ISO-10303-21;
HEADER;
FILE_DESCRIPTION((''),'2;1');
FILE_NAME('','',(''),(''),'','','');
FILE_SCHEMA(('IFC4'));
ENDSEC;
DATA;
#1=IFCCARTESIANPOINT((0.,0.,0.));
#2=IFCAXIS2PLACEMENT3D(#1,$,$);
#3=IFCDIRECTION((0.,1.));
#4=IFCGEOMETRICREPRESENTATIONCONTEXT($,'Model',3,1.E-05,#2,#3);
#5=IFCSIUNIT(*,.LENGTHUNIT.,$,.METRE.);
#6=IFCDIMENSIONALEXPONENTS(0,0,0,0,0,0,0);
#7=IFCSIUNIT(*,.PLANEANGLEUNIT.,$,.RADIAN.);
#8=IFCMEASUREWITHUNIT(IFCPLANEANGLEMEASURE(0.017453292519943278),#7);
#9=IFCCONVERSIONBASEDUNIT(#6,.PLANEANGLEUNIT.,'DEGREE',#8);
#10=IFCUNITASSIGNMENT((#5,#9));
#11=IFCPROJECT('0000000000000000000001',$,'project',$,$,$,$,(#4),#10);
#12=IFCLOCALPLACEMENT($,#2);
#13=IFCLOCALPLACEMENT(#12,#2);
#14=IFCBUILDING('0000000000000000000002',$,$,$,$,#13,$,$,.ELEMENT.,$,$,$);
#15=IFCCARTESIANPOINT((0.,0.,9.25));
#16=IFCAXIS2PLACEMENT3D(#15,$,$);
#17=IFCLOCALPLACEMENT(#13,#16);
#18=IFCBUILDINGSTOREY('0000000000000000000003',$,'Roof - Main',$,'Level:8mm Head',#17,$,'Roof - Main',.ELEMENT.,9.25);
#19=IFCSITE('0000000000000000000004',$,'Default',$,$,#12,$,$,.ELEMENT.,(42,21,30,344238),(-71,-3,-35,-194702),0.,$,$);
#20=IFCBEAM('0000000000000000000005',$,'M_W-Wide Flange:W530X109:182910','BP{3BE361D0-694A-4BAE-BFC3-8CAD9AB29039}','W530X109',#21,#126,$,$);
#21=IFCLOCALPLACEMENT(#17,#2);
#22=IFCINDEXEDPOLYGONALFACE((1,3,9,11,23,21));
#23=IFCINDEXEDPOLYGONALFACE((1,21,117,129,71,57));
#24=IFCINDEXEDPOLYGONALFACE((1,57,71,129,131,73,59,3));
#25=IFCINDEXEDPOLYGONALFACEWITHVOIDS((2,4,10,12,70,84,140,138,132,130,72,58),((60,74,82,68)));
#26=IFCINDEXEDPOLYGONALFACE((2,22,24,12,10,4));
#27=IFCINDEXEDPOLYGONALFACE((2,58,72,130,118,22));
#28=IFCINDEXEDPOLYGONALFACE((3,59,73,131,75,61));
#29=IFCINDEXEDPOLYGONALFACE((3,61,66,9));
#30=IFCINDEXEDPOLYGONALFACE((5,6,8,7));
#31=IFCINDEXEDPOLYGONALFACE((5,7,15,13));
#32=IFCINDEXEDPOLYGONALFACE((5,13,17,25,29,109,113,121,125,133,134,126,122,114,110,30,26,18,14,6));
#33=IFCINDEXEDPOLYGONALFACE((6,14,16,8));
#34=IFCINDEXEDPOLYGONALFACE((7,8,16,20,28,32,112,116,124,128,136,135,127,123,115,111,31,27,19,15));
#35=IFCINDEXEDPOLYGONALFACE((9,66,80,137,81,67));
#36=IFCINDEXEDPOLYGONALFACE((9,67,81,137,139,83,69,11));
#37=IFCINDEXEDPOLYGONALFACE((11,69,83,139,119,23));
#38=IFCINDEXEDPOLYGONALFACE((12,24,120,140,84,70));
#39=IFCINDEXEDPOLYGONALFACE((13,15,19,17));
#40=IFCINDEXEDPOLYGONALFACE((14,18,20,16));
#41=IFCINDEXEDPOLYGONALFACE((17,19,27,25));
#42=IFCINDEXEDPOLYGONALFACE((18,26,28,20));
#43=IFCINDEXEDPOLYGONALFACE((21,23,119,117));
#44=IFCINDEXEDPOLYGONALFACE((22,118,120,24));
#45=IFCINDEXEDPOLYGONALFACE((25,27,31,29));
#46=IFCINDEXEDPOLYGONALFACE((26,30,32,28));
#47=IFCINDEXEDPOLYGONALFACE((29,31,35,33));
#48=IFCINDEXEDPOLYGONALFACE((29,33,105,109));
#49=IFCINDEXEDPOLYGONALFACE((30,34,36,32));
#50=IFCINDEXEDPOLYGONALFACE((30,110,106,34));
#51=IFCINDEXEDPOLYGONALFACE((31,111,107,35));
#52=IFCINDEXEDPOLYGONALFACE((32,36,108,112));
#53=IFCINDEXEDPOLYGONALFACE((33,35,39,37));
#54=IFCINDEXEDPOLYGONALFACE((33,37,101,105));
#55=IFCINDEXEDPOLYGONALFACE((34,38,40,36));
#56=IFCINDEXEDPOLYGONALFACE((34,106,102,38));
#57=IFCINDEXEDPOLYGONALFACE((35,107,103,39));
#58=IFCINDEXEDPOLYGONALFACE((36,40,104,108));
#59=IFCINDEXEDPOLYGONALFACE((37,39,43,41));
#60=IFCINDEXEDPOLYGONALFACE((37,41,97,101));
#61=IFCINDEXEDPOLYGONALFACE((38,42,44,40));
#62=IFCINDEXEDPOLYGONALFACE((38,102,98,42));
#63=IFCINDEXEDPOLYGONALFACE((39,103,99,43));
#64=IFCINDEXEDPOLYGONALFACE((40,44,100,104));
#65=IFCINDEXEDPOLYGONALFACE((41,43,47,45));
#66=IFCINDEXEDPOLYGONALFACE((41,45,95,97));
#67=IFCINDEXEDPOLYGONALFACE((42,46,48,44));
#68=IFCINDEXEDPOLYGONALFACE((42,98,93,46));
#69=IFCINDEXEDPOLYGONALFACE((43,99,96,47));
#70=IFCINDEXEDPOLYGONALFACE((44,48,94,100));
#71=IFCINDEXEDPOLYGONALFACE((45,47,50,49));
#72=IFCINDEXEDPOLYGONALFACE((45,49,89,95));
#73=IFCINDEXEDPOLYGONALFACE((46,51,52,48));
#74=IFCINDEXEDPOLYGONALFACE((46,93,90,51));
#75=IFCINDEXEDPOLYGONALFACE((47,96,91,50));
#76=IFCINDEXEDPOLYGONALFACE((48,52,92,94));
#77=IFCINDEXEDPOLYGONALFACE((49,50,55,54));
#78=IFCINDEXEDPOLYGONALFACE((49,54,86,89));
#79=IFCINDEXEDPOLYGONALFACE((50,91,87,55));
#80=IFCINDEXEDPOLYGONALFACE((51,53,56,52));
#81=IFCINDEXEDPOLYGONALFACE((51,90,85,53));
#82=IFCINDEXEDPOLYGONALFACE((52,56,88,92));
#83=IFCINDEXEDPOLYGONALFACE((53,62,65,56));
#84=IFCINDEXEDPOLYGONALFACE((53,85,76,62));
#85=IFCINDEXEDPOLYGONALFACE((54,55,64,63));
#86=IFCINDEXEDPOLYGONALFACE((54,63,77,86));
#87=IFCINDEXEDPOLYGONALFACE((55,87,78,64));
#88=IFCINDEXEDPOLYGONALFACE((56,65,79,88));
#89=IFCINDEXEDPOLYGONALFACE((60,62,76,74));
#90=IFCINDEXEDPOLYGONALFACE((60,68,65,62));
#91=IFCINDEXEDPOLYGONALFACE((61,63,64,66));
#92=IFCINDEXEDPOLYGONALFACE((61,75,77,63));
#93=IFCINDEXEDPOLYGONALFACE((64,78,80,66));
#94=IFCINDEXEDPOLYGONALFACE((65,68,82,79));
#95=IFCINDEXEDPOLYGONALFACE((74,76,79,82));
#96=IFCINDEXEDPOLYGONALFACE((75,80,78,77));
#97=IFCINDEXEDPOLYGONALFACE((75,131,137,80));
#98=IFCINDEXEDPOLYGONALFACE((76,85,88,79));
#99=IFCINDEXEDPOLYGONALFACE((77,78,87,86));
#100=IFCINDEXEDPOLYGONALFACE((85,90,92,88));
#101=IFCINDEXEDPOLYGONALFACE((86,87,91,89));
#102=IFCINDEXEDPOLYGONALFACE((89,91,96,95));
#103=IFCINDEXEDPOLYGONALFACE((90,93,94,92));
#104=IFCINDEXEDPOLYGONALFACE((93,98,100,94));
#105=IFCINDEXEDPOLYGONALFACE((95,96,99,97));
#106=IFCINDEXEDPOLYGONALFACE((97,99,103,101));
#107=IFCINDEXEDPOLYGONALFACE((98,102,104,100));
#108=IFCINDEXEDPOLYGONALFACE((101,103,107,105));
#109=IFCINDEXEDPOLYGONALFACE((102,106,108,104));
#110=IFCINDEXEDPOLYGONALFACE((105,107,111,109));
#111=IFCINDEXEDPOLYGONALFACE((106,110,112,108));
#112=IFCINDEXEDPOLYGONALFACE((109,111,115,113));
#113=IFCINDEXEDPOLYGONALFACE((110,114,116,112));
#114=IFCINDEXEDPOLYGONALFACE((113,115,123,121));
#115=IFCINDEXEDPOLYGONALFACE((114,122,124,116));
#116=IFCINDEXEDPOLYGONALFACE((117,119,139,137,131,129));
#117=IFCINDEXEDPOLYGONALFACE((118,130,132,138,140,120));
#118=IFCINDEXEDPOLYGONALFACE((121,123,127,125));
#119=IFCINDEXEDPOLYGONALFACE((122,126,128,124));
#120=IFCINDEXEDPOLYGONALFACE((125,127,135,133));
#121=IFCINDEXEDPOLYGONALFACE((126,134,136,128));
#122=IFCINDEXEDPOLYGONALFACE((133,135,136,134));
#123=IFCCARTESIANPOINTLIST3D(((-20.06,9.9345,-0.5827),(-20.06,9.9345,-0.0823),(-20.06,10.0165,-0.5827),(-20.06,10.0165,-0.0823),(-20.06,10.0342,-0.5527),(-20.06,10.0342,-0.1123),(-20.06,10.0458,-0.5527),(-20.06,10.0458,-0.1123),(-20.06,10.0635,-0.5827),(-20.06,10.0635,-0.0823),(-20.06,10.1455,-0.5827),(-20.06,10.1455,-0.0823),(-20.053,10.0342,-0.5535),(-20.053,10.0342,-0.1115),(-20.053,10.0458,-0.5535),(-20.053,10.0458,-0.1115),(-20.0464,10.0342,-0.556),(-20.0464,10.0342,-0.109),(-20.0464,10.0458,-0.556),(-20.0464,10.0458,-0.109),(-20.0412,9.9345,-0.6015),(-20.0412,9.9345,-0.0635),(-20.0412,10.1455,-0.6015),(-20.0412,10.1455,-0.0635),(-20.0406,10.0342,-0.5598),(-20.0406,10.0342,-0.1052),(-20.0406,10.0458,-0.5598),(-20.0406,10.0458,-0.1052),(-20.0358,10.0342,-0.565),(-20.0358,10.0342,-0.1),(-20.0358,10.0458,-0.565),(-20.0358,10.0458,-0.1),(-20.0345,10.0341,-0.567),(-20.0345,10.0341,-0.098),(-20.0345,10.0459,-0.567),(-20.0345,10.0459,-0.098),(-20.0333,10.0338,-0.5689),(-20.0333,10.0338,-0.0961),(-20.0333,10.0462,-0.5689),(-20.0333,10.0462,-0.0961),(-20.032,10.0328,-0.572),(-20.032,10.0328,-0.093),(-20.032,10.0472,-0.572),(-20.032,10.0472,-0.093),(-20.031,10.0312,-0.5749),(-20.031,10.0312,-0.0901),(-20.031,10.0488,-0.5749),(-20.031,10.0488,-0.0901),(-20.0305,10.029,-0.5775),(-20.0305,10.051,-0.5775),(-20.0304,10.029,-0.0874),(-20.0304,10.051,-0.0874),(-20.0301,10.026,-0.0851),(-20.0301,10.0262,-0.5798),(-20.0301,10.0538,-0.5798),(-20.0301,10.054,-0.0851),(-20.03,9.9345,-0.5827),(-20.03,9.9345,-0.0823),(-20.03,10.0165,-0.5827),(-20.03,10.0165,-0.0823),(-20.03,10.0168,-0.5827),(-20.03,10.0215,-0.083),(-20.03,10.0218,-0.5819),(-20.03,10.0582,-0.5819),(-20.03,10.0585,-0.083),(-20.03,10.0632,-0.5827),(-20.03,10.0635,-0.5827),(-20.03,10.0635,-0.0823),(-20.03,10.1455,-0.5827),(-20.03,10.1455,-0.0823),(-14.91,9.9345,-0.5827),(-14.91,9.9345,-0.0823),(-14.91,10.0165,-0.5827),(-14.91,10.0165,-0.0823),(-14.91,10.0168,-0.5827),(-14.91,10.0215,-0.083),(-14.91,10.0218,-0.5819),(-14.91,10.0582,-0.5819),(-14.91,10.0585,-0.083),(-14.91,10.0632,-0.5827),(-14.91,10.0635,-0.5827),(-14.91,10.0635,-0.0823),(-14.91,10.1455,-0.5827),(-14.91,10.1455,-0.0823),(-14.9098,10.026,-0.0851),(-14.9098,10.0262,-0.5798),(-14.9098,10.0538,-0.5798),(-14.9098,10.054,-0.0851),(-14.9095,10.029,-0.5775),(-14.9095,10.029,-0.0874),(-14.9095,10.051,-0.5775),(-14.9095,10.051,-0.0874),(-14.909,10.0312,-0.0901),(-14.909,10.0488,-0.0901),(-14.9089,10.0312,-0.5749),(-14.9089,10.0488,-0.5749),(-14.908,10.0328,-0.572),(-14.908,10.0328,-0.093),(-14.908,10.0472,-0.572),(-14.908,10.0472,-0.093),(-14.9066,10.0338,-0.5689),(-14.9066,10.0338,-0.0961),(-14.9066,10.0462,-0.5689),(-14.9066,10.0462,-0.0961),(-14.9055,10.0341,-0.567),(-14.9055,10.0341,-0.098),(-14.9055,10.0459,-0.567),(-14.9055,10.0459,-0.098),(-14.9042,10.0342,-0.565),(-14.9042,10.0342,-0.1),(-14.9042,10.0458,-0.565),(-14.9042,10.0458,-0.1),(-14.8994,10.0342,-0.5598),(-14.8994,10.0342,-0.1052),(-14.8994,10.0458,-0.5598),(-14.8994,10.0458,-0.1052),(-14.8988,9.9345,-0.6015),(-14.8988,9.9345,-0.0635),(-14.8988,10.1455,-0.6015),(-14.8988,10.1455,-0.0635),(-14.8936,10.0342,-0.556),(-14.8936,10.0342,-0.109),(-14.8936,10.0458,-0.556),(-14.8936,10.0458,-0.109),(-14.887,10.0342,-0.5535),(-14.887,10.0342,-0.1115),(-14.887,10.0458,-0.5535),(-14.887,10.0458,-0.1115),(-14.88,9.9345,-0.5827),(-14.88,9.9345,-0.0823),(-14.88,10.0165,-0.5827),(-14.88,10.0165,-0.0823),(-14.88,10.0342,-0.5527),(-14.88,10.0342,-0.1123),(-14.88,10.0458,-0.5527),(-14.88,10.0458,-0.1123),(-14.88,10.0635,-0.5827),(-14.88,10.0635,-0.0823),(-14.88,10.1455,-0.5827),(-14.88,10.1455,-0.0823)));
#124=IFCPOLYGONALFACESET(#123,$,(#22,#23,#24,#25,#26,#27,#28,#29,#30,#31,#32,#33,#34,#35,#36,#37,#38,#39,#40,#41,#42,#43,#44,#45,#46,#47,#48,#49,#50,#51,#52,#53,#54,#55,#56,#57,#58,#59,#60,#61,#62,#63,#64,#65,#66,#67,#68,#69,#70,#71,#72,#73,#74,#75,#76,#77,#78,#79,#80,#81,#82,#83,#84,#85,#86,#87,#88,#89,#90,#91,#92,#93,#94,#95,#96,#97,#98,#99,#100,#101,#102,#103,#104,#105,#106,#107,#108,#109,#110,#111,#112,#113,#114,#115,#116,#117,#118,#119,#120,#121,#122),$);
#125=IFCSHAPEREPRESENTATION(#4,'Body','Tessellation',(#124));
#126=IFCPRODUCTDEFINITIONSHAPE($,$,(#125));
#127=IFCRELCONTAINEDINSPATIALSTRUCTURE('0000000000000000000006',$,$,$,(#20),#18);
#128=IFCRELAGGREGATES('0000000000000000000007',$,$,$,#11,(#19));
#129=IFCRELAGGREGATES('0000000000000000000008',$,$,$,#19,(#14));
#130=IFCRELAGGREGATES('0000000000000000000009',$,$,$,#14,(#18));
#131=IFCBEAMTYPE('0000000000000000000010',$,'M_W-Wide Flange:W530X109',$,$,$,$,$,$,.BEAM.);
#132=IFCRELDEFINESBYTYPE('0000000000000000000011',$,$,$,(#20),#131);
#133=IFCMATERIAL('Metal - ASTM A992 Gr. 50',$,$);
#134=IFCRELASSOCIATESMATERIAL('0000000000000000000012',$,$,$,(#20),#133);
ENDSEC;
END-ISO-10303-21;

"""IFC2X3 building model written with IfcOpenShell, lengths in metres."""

from ifc_helpers import new_model, entity, si_unit, converted_unit, point, direction, frame, frame_2d, origin, origin_2d, place, context, project, spatial, polyline, circle_curve, line_curve, trimmed, segment, composite_curve, i_section, outline, extrude, material, type_object, element, save


model = new_model("IFC2X3")

# Units and contexts
model_context = context("Model", 3, precision=1e-05, world=origin(), true_north=direction((0.0, 1.0)))
ifc_project = project(units=[si_unit("LENGTHUNIT", "METRE"), converted_unit("PLANEANGLEUNIT", "DEGREE", entity("IfcPlaneAngleMeasure", 0.017453292519943278), si_unit("PLANEANGLEUNIT", "RADIAN"), dimensions=[0, 0, 0, 0, 0, 0, 0])], contexts=[model_context])

# Site, building, storey
site_placement = place(None, origin())
site = spatial("IfcSite", under=ifc_project, at=site_placement, Name="Default", CompositionType="ELEMENT", RefLatitude=(42, 21, 30, 344238), RefLongitude=(-71, -3, -35, -194702), RefElevation=0.0)
building_placement = place(site_placement, origin())
building = spatial("IfcBuilding", under=site, at=building_placement, CompositionType="ELEMENT")
storey_placement = place(building_placement, frame((0.0, 0.0, 9.25)))
storey = spatial("IfcBuildingStorey", under=building, at=storey_placement, Name="Roof - Main", ObjectType="Level:8mm Head", LongName="Roof - Main", CompositionType="ELEMENT", Elevation=9.25)

# Beam, openings
ifc_material_1 = material(Name="Metal - ASTM A992 Gr. 50")
beam_type_1 = type_object("IfcBeamType", Name="M_W-Wide Flange:W530X109", PredefinedType="BEAM")
beam_1_placement = place(storey_placement, frame((-14.88, 10.04, -0.3325), z_axis=(1.0, 0.0, 0.0), x_axis=(0.0, 1.0, 0.0)))
beam_1 = element("IfcBeam", 1, at=beam_1_placement, inside=storey, type_object=beam_type_1, material=ifc_material_1, Name="M_W-Wide Flange:W530X109:182910", Description="BP{3BE361D0-694A-4BAE-BFC3-8CAD9AB29039}", ObjectType="W530X109", context=model_context, shape_type="SweptSolid", body=[
    extrude(i_section(OverallWidth=0.211, OverallDepth=0.538, WebThickness=0.0116, FlangeThickness=0.0188, FilletRadius=0.0177, at=origin_2d()), origin(), (0.0, 0.0, -1.0), 5.18),
])
opening_1_placement = place(beam_1_placement, frame((-0.2056, 0.269, -5.18), z_axis=(1.0, 0.0, 0.0), x_axis=(0.0, 0.0, -1.0)))
element("IfcOpeningElement", 2, at=opening_1_placement, cuts=beam_1, ObjectType="Opening", context=model_context, shape_type="SweptSolid", body=[
    extrude(outline(polyline([(0.0, -0.0188), (0.0, 0.0), (-0.0188, 0.0), (0.0, -0.0188)])), origin(), (0.0, 0.0, 1.0), 0.4112),
])
opening_2_placement = place(beam_1_placement, frame((0.2056, 0.269, -5.18), z_axis=(-1.0, 0.0, 0.0), x_axis=(0.0, 0.0, 1.0)))
element("IfcOpeningElement", 3, at=opening_2_placement, cuts=beam_1, ObjectType="Opening", context=model_context, shape_type="SweptSolid", body=[
    extrude(outline(polyline([(0.0, -0.5192), (0.0, -0.538), (0.0188, -0.538), (0.0, -0.5192)])), origin(), (0.0, 0.0, 1.0), 0.4112),
])
opening_3_placement = place(beam_1_placement, frame((-0.2056, 0.269, -5.18), z_axis=(1.0, 0.0, 0.0), x_axis=(0.0, 0.0, -1.0)))
element("IfcOpeningElement", 4, at=opening_3_placement, cuts=beam_1, ObjectType="Opening", context=model_context, shape_type="SweptSolid", body=[
    extrude(outline(composite_curve([segment(trimmed(circle_curve(frame_2d((0.0, -0.0188), x_axis=(1.0, 0.0)), 0.03), [point((-0.03, -0.0188))], [point((0.03, -0.0188))], True, "CARTESIAN"), True, "CONTINUOUS"), segment(trimmed(line_curve((0.03, -0.0188), (-1.0, 0.0), 0.06), [point((0.03, -0.0188))], [point((-0.03, -0.0188))], True, "CARTESIAN"), True, "CONTINUOUS")], self_intersect="UNKNOWN")), origin(), (0.0, 0.0, 1.0), 0.4112),
])
opening_4_placement = place(beam_1_placement, frame((0.2056, 0.269, -5.18), z_axis=(-1.0, 0.0, 0.0), x_axis=(0.0, 0.0, 1.0)))
element("IfcOpeningElement", 5, at=opening_4_placement, cuts=beam_1, ObjectType="Opening", context=model_context, shape_type="SweptSolid", body=[
    extrude(outline(composite_curve([segment(trimmed(circle_curve(frame_2d((0.0, -0.5192), x_axis=(1.0, 0.0)), 0.03), [point((0.03, -0.5192))], [point((-0.03, -0.5192))], True, "CARTESIAN"), True, "CONTINUOUS"), segment(trimmed(line_curve((-0.03, -0.5192), (1.0, 0.0), 0.06), [point((-0.03, -0.5192))], [point((0.03, -0.5192))], True, "CARTESIAN"), True, "CONTINUOUS")], self_intersect="UNKNOWN")), origin(), (0.0, 0.0, 1.0), 0.4112),
])
opening_5_placement = place(beam_1_placement, frame((0.2056, 0.269, 0.0), z_axis=(-1.0, 0.0, 0.0), x_axis=(0.0, 0.0, 1.0)))
element("IfcOpeningElement", 6, at=opening_5_placement, cuts=beam_1, ObjectType="Opening", context=model_context, shape_type="SweptSolid", body=[
    extrude(outline(polyline([(0.0, -0.0188), (0.0, 0.0), (-0.0188, 0.0), (0.0, -0.0188)])), origin(), (0.0, 0.0, 1.0), 0.4112),
])
opening_6_placement = place(beam_1_placement, frame((-0.2056, 0.269, 0.0), z_axis=(1.0, 0.0, 0.0), x_axis=(0.0, 0.0, -1.0)))
element("IfcOpeningElement", 7, at=opening_6_placement, cuts=beam_1, ObjectType="Opening", context=model_context, shape_type="SweptSolid", body=[
    extrude(outline(polyline([(0.0, -0.5192), (0.0, -0.538), (0.0188, -0.538), (0.0, -0.5192)])), origin(), (0.0, 0.0, 1.0), 0.4112),
])
opening_7_placement = place(beam_1_placement, frame((0.2056, 0.269, 0.0), z_axis=(-1.0, 0.0, 0.0), x_axis=(0.0, 0.0, 1.0)))
element("IfcOpeningElement", 8, at=opening_7_placement, cuts=beam_1, ObjectType="Opening", context=model_context, shape_type="SweptSolid", body=[
    extrude(outline(composite_curve([segment(trimmed(circle_curve(frame_2d((0.0, -0.0188), x_axis=(1.0, 0.0)), 0.03), [point((-0.03, -0.0188))], [point((0.03, -0.0188))], True, "CARTESIAN"), True, "CONTINUOUS"), segment(trimmed(line_curve((0.03, -0.0188), (-1.0, 0.0), 0.06), [point((0.03, -0.0188))], [point((-0.03, -0.0188))], True, "CARTESIAN"), True, "CONTINUOUS")], self_intersect="UNKNOWN")), origin(), (0.0, 0.0, 1.0), 0.4112),
])
opening_8_placement = place(beam_1_placement, frame((-0.2056, 0.269, 0.0), z_axis=(1.0, 0.0, 0.0), x_axis=(0.0, 0.0, -1.0)))
element("IfcOpeningElement", 9, at=opening_8_placement, cuts=beam_1, ObjectType="Opening", context=model_context, shape_type="SweptSolid", body=[
    extrude(outline(composite_curve([segment(trimmed(circle_curve(frame_2d((0.0, -0.5192), x_axis=(1.0, 0.0)), 0.03), [point((0.03, -0.5192))], [point((-0.03, -0.5192))], True, "CARTESIAN"), True, "CONTINUOUS"), segment(trimmed(line_curve((-0.03, -0.5192), (1.0, 0.0), 0.06), [point((-0.03, -0.5192))], [point((0.03, -0.5192))], True, "CARTESIAN"), True, "CONTINUOUS")], self_intersect="UNKNOWN")), origin(), (0.0, 0.0, 1.0), 0.4112),
])

save(model, "model.ifc")
